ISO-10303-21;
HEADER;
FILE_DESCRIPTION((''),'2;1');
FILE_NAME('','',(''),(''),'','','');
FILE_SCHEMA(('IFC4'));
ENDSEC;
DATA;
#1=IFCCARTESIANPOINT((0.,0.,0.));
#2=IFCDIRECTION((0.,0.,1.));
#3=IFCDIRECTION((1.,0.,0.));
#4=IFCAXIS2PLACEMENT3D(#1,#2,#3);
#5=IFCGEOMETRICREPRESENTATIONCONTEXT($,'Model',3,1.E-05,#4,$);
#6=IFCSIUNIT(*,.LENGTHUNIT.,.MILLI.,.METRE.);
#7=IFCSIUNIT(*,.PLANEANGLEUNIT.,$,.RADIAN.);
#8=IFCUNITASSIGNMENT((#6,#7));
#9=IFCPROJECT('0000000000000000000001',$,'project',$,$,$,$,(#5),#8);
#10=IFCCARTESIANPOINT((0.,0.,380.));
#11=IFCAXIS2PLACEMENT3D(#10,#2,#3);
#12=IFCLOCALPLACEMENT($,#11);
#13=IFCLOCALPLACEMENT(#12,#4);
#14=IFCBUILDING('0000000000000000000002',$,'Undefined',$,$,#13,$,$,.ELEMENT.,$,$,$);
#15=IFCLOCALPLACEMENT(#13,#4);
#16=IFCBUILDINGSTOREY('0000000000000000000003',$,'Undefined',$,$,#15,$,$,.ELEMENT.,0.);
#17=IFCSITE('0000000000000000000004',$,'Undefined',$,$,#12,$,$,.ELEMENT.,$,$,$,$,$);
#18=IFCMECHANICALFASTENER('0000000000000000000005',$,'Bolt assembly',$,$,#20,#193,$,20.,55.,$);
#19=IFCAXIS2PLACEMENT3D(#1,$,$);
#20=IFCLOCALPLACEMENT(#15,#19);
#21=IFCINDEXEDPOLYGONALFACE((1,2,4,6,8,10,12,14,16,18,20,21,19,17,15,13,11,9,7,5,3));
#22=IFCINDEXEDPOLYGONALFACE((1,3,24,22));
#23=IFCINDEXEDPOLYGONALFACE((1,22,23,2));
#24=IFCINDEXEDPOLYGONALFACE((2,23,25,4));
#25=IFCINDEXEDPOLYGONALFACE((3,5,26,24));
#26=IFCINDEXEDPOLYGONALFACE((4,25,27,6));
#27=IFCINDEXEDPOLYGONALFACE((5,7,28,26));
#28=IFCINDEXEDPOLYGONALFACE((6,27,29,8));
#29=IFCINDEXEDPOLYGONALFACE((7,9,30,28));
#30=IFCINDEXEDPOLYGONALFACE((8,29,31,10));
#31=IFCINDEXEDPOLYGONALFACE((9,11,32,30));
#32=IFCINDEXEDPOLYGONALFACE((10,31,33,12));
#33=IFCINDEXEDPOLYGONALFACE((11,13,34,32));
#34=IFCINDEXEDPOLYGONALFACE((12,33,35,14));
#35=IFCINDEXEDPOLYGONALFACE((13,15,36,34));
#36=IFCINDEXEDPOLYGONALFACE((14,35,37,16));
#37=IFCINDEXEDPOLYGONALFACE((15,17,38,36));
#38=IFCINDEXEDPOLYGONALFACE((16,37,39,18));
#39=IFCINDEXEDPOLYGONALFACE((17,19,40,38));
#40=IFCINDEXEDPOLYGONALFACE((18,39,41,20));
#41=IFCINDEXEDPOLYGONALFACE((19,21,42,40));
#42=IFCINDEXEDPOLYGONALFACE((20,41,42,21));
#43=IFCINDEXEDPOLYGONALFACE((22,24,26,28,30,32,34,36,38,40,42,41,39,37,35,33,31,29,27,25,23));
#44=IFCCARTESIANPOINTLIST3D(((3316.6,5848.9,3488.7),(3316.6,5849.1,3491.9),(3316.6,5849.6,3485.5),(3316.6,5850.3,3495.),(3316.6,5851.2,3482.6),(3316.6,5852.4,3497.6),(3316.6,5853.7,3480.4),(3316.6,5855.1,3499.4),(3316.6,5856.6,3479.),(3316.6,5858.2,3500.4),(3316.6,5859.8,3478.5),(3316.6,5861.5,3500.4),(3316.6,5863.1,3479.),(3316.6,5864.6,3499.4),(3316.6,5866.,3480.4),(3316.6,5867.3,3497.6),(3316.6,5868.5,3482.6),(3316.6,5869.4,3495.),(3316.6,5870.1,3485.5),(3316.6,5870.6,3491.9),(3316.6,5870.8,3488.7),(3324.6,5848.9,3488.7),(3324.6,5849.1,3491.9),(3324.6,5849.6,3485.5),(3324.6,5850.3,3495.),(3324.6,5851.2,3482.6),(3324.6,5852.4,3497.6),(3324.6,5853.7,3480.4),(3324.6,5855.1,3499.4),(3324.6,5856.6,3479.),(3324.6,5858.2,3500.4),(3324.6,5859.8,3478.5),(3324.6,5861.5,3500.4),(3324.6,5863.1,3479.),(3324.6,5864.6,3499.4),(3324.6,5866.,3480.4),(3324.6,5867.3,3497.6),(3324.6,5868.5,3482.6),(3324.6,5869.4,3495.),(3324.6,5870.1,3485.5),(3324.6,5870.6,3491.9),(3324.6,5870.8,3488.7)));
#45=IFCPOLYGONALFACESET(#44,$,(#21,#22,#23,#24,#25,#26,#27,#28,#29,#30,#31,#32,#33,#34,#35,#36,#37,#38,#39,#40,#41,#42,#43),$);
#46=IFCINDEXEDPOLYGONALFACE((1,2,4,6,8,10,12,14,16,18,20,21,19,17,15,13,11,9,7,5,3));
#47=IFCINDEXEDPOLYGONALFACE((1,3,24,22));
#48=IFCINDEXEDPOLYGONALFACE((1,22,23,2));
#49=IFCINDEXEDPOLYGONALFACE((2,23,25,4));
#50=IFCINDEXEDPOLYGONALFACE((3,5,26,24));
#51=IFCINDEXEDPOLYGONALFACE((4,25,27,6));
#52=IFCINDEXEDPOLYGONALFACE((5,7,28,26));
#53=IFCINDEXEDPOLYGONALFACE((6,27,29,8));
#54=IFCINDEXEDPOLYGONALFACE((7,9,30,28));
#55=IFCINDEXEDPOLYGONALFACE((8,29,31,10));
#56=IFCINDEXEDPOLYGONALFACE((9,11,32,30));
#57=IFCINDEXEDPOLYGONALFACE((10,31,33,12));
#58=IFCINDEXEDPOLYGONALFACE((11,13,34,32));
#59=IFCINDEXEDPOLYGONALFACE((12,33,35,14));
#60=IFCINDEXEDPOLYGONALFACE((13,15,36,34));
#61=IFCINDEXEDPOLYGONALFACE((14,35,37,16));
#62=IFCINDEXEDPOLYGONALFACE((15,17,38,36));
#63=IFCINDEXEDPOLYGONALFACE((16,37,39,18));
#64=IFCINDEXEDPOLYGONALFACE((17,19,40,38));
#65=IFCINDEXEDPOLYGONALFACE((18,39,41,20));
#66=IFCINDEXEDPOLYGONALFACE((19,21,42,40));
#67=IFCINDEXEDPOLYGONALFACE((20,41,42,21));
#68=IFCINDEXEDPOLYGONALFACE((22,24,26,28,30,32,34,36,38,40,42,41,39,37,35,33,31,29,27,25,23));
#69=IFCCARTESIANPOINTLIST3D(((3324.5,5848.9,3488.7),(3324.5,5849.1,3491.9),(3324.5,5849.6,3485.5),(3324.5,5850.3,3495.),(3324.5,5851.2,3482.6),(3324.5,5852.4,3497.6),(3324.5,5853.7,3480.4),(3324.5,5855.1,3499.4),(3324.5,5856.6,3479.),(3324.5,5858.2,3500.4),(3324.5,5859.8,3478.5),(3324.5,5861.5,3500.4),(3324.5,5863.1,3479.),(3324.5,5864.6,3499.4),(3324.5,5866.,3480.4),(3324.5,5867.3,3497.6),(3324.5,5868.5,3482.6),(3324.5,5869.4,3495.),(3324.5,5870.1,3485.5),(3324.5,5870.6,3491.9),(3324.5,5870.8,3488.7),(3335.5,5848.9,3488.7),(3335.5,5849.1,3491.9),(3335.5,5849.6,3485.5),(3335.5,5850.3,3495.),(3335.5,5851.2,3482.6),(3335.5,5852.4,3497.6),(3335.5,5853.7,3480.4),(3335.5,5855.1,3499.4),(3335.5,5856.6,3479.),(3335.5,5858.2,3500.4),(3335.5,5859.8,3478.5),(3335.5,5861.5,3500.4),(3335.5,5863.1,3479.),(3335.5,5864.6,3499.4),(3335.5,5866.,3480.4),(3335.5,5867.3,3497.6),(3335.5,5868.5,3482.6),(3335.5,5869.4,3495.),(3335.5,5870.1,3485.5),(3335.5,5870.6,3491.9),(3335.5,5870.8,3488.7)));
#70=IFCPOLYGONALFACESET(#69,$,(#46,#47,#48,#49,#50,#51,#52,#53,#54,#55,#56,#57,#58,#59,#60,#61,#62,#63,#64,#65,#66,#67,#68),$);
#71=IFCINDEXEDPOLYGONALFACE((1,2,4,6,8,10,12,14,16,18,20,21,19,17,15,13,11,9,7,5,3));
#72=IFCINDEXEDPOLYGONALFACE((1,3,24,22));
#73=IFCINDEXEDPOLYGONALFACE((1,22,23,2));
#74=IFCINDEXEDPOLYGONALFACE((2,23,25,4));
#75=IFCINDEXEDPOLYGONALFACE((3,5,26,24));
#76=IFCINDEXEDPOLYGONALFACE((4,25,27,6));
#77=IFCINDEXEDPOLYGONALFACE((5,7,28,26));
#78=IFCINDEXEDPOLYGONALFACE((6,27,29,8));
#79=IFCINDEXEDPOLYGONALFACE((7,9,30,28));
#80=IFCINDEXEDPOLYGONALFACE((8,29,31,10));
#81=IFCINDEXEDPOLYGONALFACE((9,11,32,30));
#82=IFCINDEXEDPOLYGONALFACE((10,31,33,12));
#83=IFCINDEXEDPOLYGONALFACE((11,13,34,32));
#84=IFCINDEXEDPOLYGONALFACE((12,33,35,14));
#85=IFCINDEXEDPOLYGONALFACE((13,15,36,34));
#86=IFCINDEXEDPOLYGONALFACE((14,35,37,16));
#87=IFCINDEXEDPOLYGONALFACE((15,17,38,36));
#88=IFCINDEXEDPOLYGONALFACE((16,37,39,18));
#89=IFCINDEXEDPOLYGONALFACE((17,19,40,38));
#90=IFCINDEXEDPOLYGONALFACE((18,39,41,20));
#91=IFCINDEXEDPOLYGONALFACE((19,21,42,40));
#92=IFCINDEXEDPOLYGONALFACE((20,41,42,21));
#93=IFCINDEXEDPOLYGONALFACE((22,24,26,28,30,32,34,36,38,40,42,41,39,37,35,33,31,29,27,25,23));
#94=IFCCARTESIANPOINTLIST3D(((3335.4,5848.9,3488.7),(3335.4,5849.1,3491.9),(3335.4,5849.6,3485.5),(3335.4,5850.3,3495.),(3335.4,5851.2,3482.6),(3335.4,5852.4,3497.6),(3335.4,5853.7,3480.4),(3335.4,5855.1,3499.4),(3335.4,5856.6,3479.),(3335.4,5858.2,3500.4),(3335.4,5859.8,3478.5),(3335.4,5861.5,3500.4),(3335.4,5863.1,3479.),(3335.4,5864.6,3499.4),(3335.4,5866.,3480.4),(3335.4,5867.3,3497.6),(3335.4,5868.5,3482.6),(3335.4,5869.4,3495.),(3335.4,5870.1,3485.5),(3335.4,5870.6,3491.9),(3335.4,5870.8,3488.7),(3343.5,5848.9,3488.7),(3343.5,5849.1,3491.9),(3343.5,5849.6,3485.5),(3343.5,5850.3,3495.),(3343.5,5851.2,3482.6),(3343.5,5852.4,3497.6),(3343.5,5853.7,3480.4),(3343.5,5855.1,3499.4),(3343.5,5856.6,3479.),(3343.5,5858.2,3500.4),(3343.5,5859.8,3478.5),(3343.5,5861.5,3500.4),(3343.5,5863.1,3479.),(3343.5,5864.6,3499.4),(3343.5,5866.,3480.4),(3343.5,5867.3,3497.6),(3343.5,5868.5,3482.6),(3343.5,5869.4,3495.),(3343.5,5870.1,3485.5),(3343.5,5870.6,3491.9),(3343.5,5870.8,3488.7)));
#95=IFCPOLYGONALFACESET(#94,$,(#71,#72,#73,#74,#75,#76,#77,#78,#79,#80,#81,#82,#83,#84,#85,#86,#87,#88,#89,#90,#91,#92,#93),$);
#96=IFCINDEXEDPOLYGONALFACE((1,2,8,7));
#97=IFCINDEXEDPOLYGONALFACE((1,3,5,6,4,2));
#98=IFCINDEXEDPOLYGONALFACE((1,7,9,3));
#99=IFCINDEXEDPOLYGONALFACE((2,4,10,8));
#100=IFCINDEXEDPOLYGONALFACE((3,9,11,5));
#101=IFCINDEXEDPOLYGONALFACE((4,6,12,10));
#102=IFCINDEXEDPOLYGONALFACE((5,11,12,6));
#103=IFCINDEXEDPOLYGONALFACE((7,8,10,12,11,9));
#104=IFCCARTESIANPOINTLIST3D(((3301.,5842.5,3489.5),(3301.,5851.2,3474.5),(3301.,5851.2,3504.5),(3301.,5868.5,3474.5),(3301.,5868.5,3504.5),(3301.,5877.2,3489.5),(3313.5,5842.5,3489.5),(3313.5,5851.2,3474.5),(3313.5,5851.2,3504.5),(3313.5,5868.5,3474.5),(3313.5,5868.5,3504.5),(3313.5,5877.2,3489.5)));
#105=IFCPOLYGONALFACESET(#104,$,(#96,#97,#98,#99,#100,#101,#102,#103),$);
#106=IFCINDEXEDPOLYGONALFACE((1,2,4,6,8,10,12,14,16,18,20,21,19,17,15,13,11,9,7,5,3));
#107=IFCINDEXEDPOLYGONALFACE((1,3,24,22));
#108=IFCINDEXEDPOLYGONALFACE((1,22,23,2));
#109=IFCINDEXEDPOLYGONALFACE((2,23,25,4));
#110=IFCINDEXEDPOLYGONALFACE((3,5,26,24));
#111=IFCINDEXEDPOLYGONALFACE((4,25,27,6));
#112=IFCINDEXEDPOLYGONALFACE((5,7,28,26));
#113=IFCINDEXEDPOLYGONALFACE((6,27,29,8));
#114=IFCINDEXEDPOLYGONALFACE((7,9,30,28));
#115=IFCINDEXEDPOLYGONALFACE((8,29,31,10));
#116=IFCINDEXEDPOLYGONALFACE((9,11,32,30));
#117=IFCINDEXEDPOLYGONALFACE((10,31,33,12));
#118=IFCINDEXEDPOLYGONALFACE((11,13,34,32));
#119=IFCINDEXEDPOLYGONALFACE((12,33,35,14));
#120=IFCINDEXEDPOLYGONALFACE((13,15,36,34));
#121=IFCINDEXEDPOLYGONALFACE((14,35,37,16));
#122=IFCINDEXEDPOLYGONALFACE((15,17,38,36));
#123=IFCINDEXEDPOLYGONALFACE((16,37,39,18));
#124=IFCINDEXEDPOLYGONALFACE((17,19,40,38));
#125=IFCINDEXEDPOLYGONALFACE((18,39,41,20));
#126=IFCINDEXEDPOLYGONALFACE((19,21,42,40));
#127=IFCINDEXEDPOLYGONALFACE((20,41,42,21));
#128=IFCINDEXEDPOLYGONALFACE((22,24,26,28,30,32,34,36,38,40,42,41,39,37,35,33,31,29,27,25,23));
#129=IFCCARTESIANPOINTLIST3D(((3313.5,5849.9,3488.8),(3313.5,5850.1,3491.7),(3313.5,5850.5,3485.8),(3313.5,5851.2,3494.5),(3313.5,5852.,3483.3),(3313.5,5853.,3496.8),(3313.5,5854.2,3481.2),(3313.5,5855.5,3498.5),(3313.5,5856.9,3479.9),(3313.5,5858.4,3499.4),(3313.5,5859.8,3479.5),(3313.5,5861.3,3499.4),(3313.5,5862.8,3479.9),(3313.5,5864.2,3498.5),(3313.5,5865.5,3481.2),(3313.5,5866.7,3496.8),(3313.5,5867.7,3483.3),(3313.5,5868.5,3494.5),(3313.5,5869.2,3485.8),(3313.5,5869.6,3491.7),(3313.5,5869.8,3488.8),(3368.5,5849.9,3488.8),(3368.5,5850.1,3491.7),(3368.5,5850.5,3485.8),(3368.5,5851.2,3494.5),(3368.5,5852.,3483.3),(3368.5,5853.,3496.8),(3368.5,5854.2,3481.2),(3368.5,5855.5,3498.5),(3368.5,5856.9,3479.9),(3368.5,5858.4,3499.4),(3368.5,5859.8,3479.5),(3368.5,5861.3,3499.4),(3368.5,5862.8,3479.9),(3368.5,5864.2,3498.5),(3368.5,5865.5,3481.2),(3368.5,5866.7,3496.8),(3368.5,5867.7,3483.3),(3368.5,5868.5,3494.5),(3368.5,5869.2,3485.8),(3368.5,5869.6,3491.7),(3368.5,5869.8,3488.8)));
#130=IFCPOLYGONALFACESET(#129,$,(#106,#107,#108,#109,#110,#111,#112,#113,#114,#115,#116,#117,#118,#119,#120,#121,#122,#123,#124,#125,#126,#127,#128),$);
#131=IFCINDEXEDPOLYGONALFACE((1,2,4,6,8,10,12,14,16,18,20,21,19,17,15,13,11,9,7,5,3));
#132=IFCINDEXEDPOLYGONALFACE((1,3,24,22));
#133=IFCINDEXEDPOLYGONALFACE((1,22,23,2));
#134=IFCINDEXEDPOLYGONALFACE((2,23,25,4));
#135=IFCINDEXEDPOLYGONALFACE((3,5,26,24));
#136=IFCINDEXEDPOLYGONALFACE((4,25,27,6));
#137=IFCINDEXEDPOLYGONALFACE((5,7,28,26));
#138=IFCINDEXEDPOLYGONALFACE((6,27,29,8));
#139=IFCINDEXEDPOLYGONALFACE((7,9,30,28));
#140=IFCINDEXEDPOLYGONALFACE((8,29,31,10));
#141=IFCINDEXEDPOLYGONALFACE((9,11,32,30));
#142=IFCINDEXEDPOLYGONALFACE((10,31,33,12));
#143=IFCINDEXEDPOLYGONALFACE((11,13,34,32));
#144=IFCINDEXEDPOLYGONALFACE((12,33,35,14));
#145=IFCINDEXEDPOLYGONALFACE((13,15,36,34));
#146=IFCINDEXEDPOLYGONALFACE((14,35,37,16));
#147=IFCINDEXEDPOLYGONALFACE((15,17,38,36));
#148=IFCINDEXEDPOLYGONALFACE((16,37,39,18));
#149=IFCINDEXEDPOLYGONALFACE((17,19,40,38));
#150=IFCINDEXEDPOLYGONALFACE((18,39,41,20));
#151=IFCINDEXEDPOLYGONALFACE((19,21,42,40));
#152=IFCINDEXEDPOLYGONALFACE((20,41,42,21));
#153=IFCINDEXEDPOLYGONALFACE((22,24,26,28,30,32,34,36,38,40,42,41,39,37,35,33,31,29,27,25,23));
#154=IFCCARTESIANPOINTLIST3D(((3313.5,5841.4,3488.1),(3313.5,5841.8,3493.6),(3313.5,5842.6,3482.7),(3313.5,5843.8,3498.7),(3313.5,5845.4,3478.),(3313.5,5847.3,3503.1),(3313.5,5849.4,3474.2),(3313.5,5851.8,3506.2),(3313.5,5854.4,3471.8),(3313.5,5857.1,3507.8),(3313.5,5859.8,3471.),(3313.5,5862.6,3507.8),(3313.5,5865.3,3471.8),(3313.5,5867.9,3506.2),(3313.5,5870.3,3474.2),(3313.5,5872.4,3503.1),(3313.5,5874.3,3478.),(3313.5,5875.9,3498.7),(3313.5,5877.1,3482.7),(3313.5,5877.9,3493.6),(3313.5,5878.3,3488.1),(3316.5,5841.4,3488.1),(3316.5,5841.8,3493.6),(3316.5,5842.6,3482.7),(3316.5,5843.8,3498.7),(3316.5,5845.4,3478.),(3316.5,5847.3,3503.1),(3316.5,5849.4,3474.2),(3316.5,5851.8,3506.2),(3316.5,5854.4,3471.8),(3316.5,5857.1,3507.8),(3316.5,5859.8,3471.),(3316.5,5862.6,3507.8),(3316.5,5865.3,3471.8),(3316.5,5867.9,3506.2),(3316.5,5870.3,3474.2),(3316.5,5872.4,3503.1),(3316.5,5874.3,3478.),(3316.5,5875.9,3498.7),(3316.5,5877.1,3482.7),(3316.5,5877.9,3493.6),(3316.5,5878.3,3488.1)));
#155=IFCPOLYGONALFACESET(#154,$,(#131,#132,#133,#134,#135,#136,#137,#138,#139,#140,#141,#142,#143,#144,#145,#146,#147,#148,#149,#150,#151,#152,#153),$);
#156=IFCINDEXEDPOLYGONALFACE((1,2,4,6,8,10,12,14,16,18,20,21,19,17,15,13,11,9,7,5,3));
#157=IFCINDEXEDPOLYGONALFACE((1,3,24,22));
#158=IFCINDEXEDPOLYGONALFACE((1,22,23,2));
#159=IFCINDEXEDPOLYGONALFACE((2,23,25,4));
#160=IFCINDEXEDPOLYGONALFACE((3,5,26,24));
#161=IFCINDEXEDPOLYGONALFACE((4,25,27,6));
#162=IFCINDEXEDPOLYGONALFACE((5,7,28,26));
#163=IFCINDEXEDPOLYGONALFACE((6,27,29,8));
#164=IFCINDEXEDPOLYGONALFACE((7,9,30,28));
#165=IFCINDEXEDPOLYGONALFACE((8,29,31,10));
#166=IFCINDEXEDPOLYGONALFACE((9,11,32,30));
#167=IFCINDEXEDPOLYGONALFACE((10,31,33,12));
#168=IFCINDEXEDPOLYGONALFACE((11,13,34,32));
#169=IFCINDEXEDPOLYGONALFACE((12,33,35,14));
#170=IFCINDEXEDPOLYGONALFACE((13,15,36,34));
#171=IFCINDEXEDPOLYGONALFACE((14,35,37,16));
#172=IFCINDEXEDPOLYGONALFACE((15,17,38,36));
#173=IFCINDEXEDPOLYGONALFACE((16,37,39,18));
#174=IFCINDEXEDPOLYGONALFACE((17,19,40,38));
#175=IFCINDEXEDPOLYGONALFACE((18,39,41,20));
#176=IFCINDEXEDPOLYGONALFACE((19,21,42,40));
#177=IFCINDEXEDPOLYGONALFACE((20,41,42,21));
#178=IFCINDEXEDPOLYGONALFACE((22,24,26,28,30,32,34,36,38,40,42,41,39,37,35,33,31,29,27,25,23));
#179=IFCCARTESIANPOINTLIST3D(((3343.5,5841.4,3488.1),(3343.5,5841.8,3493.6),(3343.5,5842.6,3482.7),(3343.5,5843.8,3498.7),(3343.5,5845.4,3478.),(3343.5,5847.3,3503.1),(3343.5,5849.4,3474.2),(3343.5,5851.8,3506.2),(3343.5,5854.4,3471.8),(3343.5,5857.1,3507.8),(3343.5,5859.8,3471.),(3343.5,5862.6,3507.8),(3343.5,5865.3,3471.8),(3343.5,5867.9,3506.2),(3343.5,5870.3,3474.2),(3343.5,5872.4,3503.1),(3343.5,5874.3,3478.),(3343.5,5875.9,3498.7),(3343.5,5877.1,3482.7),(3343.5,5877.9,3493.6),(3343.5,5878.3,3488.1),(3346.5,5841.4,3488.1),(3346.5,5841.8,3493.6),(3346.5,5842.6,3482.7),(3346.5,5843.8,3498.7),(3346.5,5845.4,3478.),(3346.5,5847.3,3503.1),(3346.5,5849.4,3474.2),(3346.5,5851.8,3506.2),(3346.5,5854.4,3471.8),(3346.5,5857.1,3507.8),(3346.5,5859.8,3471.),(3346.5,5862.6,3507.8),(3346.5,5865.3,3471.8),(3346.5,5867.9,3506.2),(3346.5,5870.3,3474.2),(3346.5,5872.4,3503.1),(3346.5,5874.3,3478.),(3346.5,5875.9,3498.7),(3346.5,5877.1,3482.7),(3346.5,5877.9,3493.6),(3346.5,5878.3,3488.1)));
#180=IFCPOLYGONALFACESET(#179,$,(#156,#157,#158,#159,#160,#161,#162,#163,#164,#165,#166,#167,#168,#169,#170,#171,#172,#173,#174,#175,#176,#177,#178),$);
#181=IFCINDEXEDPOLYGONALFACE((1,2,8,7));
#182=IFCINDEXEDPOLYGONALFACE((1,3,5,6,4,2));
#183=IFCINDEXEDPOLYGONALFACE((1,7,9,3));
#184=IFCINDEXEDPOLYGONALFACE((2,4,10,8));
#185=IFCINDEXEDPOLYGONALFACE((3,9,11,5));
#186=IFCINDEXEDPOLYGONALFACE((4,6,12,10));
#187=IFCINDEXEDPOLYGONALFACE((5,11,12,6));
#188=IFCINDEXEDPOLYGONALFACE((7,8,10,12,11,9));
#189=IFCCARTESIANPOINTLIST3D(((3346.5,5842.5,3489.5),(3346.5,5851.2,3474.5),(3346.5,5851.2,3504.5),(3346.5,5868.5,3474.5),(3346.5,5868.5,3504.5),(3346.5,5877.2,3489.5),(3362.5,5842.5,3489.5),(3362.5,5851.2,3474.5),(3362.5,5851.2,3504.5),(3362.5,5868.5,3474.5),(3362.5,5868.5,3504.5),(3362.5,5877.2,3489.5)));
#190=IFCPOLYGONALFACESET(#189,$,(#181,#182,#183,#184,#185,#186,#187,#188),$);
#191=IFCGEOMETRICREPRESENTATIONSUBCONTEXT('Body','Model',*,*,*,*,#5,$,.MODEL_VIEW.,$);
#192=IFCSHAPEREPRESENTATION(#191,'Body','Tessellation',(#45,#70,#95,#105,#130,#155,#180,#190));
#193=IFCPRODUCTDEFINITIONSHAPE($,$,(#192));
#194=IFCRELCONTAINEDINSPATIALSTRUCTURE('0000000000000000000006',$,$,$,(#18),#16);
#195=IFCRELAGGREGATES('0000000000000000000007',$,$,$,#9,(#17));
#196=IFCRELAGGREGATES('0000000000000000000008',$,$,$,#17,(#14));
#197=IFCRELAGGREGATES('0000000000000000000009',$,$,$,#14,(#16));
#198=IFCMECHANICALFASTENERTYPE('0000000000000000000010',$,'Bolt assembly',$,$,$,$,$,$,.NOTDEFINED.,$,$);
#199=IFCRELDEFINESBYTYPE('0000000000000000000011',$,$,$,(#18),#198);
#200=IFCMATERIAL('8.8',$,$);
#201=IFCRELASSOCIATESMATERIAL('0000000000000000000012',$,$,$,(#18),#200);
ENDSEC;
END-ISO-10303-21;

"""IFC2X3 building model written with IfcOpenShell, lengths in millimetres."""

from ifc_helpers import new_model, si_unit, frame, origin_with_axes, origin_2d_with_axis, place, context, subcontext, project, spatial, polyline, circle, outline, extrude, source, transform, mapped, material, type_object, element, save


model = new_model("IFC2X3")

# Units and contexts
model_context = context("Model", 3, precision=1e-05, world=origin_with_axes())
body_context = subcontext(model_context, "Body", "Model", "MODEL_VIEW")
ifc_project = project(units=[si_unit("LENGTHUNIT", "METRE", prefix="MILLI"), si_unit("PLANEANGLEUNIT", "RADIAN")], contexts=[model_context])

# Site, building, storey
site_placement = place(None, frame((0.0, 0.0, 380.0), z_axis=(0.0, 0.0, 1.0), x_axis=(1.0, 0.0, 0.0)))
site = spatial("IfcSite", under=ifc_project, at=site_placement, Name="Undefined", CompositionType="ELEMENT")
building_placement = place(site_placement, origin_with_axes())
building = spatial("IfcBuilding", under=site, at=building_placement, Name="Undefined", CompositionType="ELEMENT")
storey_placement = place(building_placement, origin_with_axes())
storey = spatial("IfcBuildingStorey", under=building, at=storey_placement, Name="Undefined", CompositionType="ELEMENT", Elevation=0.0)

# Mechanical fastener
ifc_material_1 = material(Name="8.8")
mechanical_fastener_type = type_object("IfcMechanicalFastenerType", Name="Bolt assembly")
shared_shape_1 = source(origin_with_axes(), body_context, "Body", "SweptSolid", [
    extrude(circle(Radius=11.0, at=origin_2d_with_axis()), frame((0.0, -18.9, 0.0), z_axis=(0.0, 1.0, 0.0), x_axis=(1.0, 0.0, 0.0)), (0.0, 0.0, 1.0), 8.0),
    extrude(circle(Radius=11.0, at=origin_2d_with_axis()), frame((0.0, -11.0, 0.0), z_axis=(0.0, 1.0, 0.0), x_axis=(1.0, 0.0, 0.0)), (0.0, 0.0, 1.0), 11.0),
    extrude(circle(Radius=11.0, at=origin_2d_with_axis()), frame((0.0, -0.1, 0.0), z_axis=(0.0, 1.0, 0.0), x_axis=(1.0, 0.0, 0.0)), (0.0, 0.0, 1.0), 8.1),
    extrude(outline(polyline([(15.0, -8.7), (15.0, 8.7), (0.0, 17.3), (-15.0, 8.7), (-15.0, -8.7), (0.0, -17.3), (15.0, -8.7)])), frame((0.0, -34.5, 0.0), z_axis=(0.0, 1.0, 0.0), x_axis=(1.0, 0.0, 0.0)), (0.0, 0.0, 1.0), 12.5),
    extrude(circle(Radius=10.0, at=origin_2d_with_axis()), frame((0.0, -22.0, 0.0), z_axis=(0.0, 1.0, 0.0), x_axis=(1.0, 0.0, 0.0)), (0.0, 0.0, 1.0), 55.0),
    extrude(circle(Radius=18.5, at=origin_2d_with_axis()), frame((0.0, -22.0, 0.0), z_axis=(0.0, 1.0, 0.0), x_axis=(1.0, 0.0, 0.0)), (0.0, 0.0, 1.0), 3.0),
    extrude(circle(Radius=18.5, at=origin_2d_with_axis()), frame((0.0, 8.0, 0.0), z_axis=(0.0, 1.0, 0.0), x_axis=(1.0, 0.0, 0.0)), (0.0, 0.0, 1.0), 3.0),
    extrude(outline(polyline([(15.0, -8.7), (15.0, 8.7), (0.0, 17.3), (-15.0, 8.7), (-15.0, -8.7), (0.0, -17.3), (15.0, -8.7)])), frame((0.0, 11.0, 0.0), z_axis=(0.0, 1.0, 0.0), x_axis=(1.0, 0.0, 0.0)), (0.0, 0.0, 1.0), 16.0),
])
for number, where, z_axis, x_axis, name in (
    (1, (3335.5, 5897.3, 3579.5), (0.0, -1.0, 0.0), (0.0, 0.0, -1.0), "Bolt assembly"),
):
    element("IfcMechanicalFastener", number, at=place(storey_placement, frame(where, z_axis=z_axis, x_axis=x_axis)), inside=storey, type_object=mechanical_fastener_type, material=ifc_material_1, Name=name, NominalDiameter=20.0, NominalLength=55.0, context=body_context, shape_type="MappedRepresentation", body=[
        mapped(shared_shape_1, transform((90.0, 0.0, 37.5))),
    ])

save(model, "model.ifc")
